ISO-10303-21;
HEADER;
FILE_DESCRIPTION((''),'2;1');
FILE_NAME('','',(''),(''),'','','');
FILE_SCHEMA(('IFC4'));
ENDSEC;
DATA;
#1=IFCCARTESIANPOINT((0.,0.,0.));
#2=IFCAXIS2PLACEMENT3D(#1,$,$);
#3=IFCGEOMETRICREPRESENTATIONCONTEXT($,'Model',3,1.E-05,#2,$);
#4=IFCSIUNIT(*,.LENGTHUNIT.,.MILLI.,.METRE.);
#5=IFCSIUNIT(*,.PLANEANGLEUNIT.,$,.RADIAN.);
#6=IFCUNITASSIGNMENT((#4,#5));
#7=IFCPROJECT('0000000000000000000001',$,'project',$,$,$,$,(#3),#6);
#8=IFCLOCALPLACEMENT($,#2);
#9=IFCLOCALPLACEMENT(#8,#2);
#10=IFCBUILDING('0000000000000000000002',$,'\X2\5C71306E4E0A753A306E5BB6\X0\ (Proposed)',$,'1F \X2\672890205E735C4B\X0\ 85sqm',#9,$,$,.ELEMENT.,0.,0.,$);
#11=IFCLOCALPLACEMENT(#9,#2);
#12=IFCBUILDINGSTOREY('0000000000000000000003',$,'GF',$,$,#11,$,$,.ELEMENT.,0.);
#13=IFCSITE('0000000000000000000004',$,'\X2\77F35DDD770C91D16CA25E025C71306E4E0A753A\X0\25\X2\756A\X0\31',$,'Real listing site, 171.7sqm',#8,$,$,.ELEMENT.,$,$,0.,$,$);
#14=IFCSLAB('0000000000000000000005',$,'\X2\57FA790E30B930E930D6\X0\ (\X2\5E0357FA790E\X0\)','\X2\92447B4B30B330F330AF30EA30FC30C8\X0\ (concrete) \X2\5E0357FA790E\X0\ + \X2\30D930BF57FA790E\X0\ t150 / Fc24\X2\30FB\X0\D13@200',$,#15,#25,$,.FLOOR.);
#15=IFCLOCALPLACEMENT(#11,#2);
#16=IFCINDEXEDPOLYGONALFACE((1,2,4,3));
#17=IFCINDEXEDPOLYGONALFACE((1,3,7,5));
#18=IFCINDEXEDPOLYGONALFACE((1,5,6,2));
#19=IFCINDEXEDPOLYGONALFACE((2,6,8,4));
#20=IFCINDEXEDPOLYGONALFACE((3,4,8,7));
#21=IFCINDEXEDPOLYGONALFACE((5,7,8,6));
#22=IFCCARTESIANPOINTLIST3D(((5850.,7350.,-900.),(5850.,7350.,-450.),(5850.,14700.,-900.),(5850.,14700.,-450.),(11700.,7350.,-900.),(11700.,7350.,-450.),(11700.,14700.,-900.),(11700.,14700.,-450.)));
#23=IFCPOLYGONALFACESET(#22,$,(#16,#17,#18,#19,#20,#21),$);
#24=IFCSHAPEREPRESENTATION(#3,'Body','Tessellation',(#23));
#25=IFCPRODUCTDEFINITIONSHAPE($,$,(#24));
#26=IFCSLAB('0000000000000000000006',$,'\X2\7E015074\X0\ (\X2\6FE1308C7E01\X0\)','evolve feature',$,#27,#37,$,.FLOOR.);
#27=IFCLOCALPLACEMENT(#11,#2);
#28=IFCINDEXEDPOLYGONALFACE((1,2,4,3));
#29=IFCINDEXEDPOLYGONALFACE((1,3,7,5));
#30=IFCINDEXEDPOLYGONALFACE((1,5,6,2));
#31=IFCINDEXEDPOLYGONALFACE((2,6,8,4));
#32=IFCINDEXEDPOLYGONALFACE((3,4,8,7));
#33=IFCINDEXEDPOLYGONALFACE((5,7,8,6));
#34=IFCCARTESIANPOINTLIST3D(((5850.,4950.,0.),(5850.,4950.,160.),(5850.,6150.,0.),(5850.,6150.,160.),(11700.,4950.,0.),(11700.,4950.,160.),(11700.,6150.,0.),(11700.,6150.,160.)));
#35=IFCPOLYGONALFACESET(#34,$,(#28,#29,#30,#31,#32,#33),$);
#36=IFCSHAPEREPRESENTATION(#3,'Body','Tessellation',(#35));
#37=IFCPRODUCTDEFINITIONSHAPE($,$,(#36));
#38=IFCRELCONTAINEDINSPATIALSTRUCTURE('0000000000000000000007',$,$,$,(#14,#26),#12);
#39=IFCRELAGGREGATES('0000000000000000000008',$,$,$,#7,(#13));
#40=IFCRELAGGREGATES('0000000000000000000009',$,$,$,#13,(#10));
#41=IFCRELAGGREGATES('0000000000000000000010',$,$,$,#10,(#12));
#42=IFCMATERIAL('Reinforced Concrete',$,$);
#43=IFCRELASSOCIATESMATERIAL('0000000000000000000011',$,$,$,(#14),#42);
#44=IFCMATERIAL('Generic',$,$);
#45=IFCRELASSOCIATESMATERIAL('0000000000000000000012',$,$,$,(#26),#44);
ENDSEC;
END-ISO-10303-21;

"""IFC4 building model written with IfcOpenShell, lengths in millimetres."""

from ifc_helpers import new_model, si_unit, frame, frame_2d, origin, place, context, project, spatial, rectangle, extrude, material, element, save


model = new_model("IFC4")

# Units and contexts
model_context = context("Model", 3, precision=1e-05, world=origin())
ifc_project = project(units=[si_unit("LENGTHUNIT", "METRE", prefix="MILLI"), si_unit("PLANEANGLEUNIT", "RADIAN")], contexts=[model_context])

# Site, building, storey
site_placement = place(None, origin())
site = spatial("IfcSite", under=ifc_project, at=site_placement, Name="石川県金沢市山の上町25番31", ObjectType="Real listing site, 171.7sqm", CompositionType="ELEMENT", RefElevation=0.0)
building_placement = place(site_placement, origin())
building = spatial("IfcBuilding", under=site, at=building_placement, Name="山の上町の家 (Proposed)", ObjectType="1F 木造平屋 85sqm", CompositionType="ELEMENT", ElevationOfRefHeight=0.0, ElevationOfTerrain=0.0)
storey_placement = place(building_placement, origin())
storey = spatial("IfcBuildingStorey", under=building, at=storey_placement, Name="GF", CompositionType="ELEMENT", Elevation=0.0)

# Slabs
ifc_material_1 = material(Name="Reinforced Concrete")
slab_1_placement = place(storey_placement, frame((2925.0, 3675.0, -450.0)))
element("IfcSlab", 1, at=slab_1_placement, inside=storey, material=ifc_material_1, Name="基礎スラブ (布基礎)", Description="鉄筋コンクリート (concrete) 布基礎 + ベタ基礎 t150 / Fc24・D13@200", PredefinedType="FLOOR", context=model_context, shape_type="SweptSolid", body=[
    extrude(rectangle(XDim=5850.0, YDim=7350.0, at=frame_2d((2925.0, 3675.0))), frame((2925.0, 3675.0, -450.0)), (0.0, 0.0, 1.0), 450.0),
])
ifc_material_2 = material(Name="Generic")
slab_2_placement = place(storey_placement, frame((2925.0, 2475.0, 0.0)))
element("IfcSlab", 2, at=slab_2_placement, inside=storey, material=ifc_material_2, Name="縁側 (濡れ縁)", Description="evolve feature", PredefinedType="FLOOR", context=model_context, shape_type="SweptSolid", body=[
    extrude(rectangle(XDim=5850.0, YDim=1200.0, at=frame_2d((2925.0, 600.0))), frame((2925.0, 2475.0, 0.0)), (0.0, 0.0, 1.0), 160.0),
])

save(model, "model.ifc")
